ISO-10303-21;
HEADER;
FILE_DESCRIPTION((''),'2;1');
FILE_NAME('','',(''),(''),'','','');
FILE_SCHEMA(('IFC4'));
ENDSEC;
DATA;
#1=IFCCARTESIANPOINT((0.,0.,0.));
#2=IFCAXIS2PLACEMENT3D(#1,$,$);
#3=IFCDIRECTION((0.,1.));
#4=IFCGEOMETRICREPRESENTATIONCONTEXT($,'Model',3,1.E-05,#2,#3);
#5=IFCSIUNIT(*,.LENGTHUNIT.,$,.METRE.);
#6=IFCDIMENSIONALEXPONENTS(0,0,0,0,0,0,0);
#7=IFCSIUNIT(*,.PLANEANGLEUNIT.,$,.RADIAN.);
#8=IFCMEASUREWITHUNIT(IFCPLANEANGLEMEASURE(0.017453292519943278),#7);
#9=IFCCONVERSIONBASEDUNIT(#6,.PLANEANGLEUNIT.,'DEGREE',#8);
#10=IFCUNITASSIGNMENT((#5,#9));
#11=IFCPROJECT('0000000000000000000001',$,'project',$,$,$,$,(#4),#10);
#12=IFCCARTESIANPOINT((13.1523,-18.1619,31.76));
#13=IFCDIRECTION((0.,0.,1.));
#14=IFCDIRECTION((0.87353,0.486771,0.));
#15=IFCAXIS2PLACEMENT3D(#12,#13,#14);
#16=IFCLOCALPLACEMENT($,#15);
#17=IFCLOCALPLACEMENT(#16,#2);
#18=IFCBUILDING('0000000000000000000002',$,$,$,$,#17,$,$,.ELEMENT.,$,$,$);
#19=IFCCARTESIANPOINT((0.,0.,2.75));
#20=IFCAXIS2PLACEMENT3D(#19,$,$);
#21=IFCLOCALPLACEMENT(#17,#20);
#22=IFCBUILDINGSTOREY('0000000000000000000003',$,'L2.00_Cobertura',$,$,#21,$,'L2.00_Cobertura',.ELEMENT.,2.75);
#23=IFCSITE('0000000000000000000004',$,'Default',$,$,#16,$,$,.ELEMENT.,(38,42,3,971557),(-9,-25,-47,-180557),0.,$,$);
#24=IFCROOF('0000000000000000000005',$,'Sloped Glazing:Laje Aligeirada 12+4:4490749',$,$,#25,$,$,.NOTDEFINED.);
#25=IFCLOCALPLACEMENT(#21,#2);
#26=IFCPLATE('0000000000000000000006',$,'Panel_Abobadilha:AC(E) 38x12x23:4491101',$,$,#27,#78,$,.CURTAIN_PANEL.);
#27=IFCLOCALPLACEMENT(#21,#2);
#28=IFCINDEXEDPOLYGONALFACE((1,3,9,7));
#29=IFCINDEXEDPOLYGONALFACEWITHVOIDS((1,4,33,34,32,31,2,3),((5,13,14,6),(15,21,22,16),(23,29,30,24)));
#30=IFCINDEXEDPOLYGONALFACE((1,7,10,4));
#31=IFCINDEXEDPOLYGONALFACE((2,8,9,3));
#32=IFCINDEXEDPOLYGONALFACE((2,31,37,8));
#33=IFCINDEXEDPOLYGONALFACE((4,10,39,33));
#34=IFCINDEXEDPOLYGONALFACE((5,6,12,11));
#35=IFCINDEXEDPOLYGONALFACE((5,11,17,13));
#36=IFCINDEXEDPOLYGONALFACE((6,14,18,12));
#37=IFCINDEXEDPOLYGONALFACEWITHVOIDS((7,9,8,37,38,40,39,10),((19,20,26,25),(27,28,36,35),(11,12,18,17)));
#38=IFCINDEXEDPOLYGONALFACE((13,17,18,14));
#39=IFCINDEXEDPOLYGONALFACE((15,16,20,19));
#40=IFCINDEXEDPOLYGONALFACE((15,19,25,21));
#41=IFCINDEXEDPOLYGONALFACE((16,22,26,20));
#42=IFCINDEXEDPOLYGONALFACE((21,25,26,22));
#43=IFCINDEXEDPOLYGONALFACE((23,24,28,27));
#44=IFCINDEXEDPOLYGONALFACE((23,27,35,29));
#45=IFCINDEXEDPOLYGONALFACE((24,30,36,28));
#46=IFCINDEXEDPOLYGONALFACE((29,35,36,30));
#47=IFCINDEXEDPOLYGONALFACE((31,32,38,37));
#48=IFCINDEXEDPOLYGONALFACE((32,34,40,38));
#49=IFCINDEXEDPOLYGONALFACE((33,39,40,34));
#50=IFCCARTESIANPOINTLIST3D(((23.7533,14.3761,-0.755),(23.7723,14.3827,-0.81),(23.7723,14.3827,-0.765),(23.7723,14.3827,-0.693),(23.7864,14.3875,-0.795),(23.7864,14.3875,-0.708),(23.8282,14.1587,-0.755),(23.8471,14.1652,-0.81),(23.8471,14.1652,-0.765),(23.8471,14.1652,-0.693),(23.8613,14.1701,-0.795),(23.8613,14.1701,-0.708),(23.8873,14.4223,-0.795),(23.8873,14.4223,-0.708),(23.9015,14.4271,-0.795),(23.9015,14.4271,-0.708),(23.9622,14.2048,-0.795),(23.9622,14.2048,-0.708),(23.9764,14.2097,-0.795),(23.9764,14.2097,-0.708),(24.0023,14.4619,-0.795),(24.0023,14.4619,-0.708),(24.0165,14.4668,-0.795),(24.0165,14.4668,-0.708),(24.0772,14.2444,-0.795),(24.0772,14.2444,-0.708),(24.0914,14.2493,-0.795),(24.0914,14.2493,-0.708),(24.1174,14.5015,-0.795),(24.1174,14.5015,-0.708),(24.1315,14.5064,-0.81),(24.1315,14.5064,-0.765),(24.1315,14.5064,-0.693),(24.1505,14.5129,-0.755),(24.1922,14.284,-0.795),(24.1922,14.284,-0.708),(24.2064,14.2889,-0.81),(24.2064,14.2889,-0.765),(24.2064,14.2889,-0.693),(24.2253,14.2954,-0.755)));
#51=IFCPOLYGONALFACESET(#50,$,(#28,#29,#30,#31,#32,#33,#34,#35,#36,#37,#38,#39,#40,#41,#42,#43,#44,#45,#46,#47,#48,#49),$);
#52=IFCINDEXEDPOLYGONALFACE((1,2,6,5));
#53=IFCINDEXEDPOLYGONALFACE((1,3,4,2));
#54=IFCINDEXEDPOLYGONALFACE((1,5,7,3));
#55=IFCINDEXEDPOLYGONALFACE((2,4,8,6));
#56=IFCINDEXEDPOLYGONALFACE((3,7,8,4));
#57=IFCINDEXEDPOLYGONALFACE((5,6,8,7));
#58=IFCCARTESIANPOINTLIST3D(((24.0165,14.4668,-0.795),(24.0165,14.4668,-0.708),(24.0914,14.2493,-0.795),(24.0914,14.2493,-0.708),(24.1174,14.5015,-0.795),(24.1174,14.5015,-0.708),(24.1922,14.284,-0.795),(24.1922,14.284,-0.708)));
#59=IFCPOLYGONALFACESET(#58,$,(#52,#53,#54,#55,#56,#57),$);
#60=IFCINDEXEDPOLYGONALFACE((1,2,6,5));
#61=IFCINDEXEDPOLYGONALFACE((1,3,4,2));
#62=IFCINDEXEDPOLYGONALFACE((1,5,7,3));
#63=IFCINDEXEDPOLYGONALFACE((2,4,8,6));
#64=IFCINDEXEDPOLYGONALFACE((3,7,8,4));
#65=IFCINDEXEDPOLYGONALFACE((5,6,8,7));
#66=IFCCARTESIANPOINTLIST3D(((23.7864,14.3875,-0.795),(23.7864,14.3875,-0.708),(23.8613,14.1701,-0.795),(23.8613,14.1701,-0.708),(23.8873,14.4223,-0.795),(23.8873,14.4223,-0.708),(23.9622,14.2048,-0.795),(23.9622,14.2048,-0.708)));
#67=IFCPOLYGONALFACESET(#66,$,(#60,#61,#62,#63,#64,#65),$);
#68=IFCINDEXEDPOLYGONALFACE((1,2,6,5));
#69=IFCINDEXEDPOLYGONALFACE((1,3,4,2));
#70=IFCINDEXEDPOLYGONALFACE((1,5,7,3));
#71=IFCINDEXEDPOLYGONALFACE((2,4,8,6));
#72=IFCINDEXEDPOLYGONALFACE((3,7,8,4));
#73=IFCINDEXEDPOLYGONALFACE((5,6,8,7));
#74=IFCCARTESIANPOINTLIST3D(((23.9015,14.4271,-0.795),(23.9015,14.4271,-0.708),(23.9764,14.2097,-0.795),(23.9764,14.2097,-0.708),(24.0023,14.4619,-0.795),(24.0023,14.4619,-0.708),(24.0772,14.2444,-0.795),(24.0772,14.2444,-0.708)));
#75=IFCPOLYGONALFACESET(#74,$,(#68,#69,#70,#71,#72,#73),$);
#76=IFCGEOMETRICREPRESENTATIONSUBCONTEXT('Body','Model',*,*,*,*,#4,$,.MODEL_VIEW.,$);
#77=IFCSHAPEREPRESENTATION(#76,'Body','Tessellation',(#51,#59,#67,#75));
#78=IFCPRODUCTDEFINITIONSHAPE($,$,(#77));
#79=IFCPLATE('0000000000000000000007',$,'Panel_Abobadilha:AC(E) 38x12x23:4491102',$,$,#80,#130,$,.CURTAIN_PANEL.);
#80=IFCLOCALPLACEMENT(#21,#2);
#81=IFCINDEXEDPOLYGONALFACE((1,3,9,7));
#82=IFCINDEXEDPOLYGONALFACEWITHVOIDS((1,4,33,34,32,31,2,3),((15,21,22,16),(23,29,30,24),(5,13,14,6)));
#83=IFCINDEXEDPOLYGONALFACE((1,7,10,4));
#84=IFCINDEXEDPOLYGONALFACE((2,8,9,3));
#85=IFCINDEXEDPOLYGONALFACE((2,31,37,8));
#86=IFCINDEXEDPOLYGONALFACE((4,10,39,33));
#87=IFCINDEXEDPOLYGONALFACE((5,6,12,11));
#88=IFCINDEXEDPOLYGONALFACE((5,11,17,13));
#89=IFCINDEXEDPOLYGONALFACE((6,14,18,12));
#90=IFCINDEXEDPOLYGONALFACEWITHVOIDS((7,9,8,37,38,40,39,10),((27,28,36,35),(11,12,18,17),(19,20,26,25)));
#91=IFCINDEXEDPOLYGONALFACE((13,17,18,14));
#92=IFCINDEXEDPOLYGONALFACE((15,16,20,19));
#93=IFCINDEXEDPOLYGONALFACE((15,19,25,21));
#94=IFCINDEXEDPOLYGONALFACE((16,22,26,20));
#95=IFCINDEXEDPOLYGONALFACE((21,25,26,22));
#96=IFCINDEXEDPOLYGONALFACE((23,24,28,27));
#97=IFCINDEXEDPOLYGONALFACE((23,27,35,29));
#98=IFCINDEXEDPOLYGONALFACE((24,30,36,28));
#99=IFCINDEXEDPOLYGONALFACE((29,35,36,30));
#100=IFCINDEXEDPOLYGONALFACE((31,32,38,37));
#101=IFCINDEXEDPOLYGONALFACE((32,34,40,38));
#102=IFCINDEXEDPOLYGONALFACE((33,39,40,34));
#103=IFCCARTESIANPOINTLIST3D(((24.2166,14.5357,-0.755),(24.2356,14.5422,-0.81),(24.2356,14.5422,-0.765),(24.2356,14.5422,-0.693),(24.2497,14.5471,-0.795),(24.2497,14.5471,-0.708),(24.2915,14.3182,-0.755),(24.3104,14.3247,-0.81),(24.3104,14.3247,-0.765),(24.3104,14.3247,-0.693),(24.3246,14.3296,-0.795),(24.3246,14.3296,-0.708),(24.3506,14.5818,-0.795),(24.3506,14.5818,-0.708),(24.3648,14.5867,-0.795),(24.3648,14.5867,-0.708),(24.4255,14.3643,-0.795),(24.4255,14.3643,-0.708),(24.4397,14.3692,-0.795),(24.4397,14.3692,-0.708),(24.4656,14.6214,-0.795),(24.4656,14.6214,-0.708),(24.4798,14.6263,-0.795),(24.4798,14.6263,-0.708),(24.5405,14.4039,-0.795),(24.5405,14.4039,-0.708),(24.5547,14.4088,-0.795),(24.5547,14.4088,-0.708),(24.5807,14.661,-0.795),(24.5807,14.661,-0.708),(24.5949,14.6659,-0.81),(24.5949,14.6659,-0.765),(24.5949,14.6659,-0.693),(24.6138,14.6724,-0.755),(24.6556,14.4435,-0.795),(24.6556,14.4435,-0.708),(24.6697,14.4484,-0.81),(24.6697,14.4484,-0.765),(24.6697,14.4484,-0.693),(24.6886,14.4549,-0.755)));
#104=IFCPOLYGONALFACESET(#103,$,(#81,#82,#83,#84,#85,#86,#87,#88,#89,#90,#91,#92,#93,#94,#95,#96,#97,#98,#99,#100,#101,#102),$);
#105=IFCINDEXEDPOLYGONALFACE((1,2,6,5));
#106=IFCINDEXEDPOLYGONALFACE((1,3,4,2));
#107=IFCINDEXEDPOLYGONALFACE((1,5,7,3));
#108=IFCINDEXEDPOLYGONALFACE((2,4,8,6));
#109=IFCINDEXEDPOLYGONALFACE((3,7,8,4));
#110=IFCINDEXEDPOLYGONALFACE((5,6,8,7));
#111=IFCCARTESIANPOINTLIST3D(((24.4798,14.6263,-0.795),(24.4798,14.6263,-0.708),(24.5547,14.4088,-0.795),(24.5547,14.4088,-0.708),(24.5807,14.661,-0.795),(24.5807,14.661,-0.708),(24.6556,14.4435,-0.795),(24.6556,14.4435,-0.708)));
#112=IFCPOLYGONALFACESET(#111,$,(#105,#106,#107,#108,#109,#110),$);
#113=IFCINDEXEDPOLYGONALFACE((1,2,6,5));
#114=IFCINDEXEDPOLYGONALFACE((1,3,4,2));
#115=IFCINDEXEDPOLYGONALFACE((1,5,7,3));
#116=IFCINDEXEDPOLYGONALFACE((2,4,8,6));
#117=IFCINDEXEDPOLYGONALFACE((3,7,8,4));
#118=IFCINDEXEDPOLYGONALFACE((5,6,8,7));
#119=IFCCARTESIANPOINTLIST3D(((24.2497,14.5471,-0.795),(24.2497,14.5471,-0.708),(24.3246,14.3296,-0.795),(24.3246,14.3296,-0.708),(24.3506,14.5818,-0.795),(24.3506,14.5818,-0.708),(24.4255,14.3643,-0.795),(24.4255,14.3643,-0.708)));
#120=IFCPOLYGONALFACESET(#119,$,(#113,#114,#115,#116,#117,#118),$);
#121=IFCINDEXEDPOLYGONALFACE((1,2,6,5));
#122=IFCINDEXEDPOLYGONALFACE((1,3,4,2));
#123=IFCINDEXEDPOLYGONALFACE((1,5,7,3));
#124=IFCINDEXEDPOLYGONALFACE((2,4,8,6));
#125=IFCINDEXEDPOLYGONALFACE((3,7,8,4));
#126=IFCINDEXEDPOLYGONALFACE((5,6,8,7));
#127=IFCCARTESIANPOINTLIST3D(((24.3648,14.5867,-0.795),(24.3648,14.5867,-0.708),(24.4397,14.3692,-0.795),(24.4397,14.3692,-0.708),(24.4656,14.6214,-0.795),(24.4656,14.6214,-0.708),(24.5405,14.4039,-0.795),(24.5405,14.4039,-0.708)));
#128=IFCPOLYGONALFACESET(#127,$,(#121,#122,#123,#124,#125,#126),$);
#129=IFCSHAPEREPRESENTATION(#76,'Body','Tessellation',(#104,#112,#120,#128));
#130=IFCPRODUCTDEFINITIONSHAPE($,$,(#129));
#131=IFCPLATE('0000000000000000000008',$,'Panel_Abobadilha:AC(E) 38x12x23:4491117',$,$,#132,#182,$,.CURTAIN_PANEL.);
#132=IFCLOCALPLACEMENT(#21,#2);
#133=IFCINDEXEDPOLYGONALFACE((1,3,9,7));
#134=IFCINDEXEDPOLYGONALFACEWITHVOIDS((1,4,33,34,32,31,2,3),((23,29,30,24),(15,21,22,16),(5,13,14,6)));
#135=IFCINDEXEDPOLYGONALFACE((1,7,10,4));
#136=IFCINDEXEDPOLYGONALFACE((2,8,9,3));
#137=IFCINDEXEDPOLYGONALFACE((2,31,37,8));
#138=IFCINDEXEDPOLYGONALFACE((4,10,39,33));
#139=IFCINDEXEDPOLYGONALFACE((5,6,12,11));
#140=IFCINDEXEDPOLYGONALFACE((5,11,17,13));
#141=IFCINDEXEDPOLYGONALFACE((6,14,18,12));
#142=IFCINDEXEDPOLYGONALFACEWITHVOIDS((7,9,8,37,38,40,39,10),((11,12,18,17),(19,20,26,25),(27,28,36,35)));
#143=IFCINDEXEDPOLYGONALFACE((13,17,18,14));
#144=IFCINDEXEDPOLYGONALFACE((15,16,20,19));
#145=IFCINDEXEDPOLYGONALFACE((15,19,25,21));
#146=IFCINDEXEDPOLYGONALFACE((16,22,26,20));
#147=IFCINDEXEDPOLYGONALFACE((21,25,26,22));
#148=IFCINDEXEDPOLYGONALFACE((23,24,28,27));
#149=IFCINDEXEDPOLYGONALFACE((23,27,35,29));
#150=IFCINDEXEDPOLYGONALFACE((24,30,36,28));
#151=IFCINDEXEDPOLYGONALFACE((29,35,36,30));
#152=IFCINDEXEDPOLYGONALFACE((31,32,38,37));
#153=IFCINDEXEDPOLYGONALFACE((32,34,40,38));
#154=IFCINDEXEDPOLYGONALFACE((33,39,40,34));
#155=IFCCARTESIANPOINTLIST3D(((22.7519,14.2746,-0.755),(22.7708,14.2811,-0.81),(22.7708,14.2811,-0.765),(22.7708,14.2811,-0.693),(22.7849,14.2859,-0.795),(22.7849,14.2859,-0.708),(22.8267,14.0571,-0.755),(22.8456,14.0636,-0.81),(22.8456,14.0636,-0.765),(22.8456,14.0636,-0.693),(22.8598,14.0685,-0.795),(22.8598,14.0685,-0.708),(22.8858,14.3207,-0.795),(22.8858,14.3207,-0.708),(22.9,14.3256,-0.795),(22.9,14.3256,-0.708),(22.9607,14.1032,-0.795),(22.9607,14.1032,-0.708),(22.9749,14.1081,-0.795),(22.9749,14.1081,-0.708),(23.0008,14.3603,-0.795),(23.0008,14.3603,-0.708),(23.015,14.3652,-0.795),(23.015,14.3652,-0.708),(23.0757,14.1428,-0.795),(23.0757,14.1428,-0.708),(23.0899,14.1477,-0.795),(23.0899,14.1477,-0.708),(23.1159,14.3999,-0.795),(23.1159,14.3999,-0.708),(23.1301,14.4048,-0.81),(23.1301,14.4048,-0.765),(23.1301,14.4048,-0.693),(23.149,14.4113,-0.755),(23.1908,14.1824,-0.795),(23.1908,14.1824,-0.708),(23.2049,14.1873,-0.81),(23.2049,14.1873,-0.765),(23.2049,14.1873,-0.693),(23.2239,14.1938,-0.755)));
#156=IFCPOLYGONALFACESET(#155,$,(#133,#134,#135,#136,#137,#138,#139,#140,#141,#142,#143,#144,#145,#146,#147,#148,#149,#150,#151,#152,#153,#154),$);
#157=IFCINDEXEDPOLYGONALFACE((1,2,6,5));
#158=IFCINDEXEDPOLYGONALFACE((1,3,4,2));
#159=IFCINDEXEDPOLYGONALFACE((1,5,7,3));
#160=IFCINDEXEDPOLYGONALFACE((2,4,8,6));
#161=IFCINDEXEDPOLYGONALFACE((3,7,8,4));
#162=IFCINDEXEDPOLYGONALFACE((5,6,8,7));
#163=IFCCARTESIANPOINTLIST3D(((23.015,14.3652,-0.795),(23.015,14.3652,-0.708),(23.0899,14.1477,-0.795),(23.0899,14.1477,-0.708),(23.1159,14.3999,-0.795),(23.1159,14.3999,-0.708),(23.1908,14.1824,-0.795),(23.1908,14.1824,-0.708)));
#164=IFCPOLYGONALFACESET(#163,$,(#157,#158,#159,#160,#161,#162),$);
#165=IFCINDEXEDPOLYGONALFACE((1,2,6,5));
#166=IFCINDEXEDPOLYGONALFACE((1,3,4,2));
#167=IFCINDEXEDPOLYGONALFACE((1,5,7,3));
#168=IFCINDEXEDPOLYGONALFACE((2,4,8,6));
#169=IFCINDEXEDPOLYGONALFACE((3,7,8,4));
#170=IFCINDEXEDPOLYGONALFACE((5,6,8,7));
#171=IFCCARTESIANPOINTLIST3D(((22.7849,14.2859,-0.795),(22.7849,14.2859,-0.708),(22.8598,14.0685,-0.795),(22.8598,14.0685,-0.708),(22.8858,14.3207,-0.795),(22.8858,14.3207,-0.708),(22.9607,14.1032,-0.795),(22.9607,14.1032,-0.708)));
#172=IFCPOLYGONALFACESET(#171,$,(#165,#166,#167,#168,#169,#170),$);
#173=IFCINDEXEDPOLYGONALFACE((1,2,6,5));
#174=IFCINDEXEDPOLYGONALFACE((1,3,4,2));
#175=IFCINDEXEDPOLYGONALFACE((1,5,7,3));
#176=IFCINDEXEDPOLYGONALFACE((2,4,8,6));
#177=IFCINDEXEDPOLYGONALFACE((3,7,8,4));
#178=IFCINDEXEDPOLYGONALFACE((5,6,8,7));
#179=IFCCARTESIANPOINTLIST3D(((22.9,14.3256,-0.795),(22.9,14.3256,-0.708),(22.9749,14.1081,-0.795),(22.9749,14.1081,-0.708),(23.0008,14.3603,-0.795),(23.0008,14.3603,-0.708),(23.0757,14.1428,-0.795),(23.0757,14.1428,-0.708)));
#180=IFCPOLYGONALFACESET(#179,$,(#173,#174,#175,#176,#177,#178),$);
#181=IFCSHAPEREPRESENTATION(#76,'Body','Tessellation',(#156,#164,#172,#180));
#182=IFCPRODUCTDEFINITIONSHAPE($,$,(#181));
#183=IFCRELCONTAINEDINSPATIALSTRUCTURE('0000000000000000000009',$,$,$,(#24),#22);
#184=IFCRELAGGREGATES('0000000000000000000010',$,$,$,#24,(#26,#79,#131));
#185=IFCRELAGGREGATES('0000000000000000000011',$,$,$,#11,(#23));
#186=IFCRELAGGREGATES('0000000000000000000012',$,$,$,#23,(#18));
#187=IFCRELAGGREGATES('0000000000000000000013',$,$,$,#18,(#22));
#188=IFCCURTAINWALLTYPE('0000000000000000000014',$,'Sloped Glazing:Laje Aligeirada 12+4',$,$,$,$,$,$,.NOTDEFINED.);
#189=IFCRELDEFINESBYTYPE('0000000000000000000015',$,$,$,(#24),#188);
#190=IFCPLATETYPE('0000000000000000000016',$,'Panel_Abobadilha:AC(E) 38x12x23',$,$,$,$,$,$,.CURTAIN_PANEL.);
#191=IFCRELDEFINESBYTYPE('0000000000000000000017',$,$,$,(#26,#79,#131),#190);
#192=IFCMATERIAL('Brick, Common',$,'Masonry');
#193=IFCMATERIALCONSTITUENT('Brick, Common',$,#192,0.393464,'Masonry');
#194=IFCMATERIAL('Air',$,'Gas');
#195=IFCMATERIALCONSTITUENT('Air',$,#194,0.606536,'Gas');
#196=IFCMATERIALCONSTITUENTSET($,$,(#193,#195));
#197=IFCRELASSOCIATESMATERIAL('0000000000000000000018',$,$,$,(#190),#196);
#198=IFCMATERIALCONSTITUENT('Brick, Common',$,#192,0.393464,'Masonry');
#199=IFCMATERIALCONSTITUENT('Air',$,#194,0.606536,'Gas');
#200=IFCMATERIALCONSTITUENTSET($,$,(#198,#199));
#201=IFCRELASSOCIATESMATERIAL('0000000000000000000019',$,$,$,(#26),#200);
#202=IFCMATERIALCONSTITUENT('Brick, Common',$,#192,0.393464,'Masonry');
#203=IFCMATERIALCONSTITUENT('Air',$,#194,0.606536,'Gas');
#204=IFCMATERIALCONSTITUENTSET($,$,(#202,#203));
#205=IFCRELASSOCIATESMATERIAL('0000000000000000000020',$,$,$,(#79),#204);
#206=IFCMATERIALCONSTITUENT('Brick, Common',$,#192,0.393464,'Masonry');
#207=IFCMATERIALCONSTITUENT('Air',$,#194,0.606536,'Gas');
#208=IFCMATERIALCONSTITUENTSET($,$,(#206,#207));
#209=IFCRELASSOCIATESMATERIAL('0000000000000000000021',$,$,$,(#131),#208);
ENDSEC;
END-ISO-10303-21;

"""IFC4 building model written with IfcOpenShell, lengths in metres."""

from ifc_helpers import new_model, entity, si_unit, converted_unit, direction, frame, origin, place, context, subcontext, project, spatial, indexed_curve, outline, extrude, source, transform, mapped, material, constituent, constituent_set, type_object, type_shapes, element, aggregate, save


model = new_model("IFC4")

# Units and contexts
model_context = context("Model", 3, precision=1e-05, world=origin(), true_north=direction((0.0, 1.0)))
body_context = subcontext(model_context, "Body", "Model", "MODEL_VIEW")
ifc_project = project(units=[si_unit("LENGTHUNIT", "METRE"), converted_unit("PLANEANGLEUNIT", "DEGREE", entity("IfcPlaneAngleMeasure", 0.017453292519943278), si_unit("PLANEANGLEUNIT", "RADIAN"), dimensions=[0, 0, 0, 0, 0, 0, 0])], contexts=[model_context])

# Site, building, storey
site_placement = place(None, frame((13.1523, -18.1619, 31.76), z_axis=(0.0, 0.0, 1.0), x_axis=(0.87353, 0.486771, 0.0)))
site = spatial("IfcSite", under=ifc_project, at=site_placement, Name="Default", CompositionType="ELEMENT", RefLatitude=(38, 42, 3, 971557), RefLongitude=(-9, -25, -47, -180557), RefElevation=0.0)
building_placement = place(site_placement, origin())
building = spatial("IfcBuilding", under=site, at=building_placement, CompositionType="ELEMENT")
storey_placement = place(building_placement, frame((0.0, 0.0, 2.75)))
storey = spatial("IfcBuildingStorey", under=building, at=storey_placement, Name="L2.00_Cobertura", LongName="L2.00_Cobertura", CompositionType="ELEMENT", Elevation=2.75)

# Roof, plates
curtain_wall_type = type_object("IfcCurtainWallType", Name="Sloped Glazing:Laje Aligeirada 12+4", PredefinedType="NOTDEFINED")
roof_placement = place(storey_placement, frame((0.0, 0.0, -2.75)))
roof = element("IfcRoof", 1, at=roof_placement, inside=storey, type_object=curtain_wall_type, Name="Sloped Glazing:Laje Aligeirada 12+4:4490749", PredefinedType="NOTDEFINED")
ifc_material_1 = material(Name="Brick, Common", Category="Masonry")
ifc_material_2 = material(Name="Air", Category="Gas")
ifc_constituent_1 = constituent(ifc_material_1, Name="Brick, Common", Category="Masonry", fraction=0.393464)
ifc_constituent_2 = constituent(ifc_material_2, Name="Air", Category="Gas", fraction=0.606536)
ifc_constituent_set_1 = constituent_set(constituents=[ifc_constituent_1, ifc_constituent_2])
plate_type = type_object("IfcPlateType", Name="Panel_Abobadilha:AC(E) 38x12x23", PredefinedType="CURTAIN_PANEL", material=ifc_constituent_set_1)
shared_shape_1 = source(origin(), body_context, "Body", "SweptSolid", [
    extrude(outline(indexed_curve([(-0.19, -0.0543), (0.19, -0.0543), (0.19, -0.0093), (0.21, 0.0007), (0.19, 0.0628), (-0.19, 0.0628), (-0.21, 0.0007), (-0.19, -0.0093), (-0.19, -0.0543)], self_intersect=False), holes=[indexed_curve([(-0.0683, 0.0477), (-0.0683, -0.0393), (-0.175, -0.0393), (-0.175, 0.0477), (-0.0683, 0.0477)], self_intersect=False), indexed_curve([(0.0533, 0.0477), (0.0533, -0.0393), (-0.0533, -0.0393), (-0.0533, 0.0477), (0.0533, 0.0477)], self_intersect=False), indexed_curve([(0.175, 0.0477), (0.175, -0.0393), (0.0683, -0.0393), (0.0683, 0.0477), (0.175, 0.0477)], self_intersect=False)]), frame((0.0, 0.0543, 0.0)), (0.0, 0.0, 1.0), 0.23),
    extrude(outline(indexed_curve([(-0.0533, -0.0435), (0.0533, -0.0435), (0.0533, 0.0435), (-0.0533, 0.0435), (-0.0533, -0.0435)], self_intersect=False)), frame((0.1217, 0.0585, 0.0), z_axis=(0.0, 0.0, 1.0), x_axis=(-1.0, 0.0, 0.0)), (0.0, 0.0, 1.0), 0.23),
    extrude(outline(indexed_curve([(-0.0533, -0.0435), (0.0533, -0.0435), (0.0533, 0.0435), (-0.0533, 0.0435), (-0.0533, -0.0435)], self_intersect=False)), frame((-0.1217, 0.0585, 0.0), z_axis=(0.0, 0.0, 1.0), x_axis=(-1.0, 0.0, 0.0)), (0.0, 0.0, 1.0), 0.23),
    extrude(outline(indexed_curve([(-0.0533, -0.0435), (0.0533, -0.0435), (0.0533, 0.0435), (-0.0533, 0.0435), (-0.0533, -0.0435)], self_intersect=False)), frame((0.0, 0.0585, 0.0), z_axis=(0.0, 0.0, 1.0), x_axis=(-1.0, 0.0, 0.0)), (0.0, 0.0, 1.0), 0.23),
])
type_shapes(plate_type, [shared_shape_1])
ifc_constituent_3 = constituent(ifc_material_1, Name="Brick, Common", Category="Masonry", fraction=0.393464)
ifc_constituent_4 = constituent(ifc_material_2, Name="Air", Category="Gas", fraction=0.606536)
ifc_constituent_set_2 = constituent_set(constituents=[ifc_constituent_3, ifc_constituent_4])
plate_1_placement = place(roof_placement, frame((23.9519, 14.4445, 1.94), z_axis=(0.325568, -0.945519, 0.0), x_axis=(0.945519, 0.325568, 0.0)))
plate_1 = element("IfcPlate", 2, at=plate_1_placement, type_object=plate_type, material=ifc_constituent_set_2, Name="Panel_Abobadilha:AC(E) 38x12x23:4491101", PredefinedType="CURTAIN_PANEL", context=body_context, shape_type="MappedRepresentation", body=[
    mapped(shared_shape_1, transform((0.0, 0.0, 0.0), scale=1.0)),
])
ifc_constituent_5 = constituent(ifc_material_1, Name="Brick, Common", Category="Masonry", fraction=0.393464)
ifc_constituent_6 = constituent(ifc_material_2, Name="Air", Category="Gas", fraction=0.606536)
ifc_constituent_set_3 = constituent_set(constituents=[ifc_constituent_5, ifc_constituent_6])
plate_2_placement = place(roof_placement, frame((24.4152, 14.604, 1.94), z_axis=(0.325568, -0.945519, 0.0), x_axis=(0.945519, 0.325568, 0.0)))
plate_2 = element("IfcPlate", 3, at=plate_2_placement, type_object=plate_type, material=ifc_constituent_set_3, Name="Panel_Abobadilha:AC(E) 38x12x23:4491102", PredefinedType="CURTAIN_PANEL", context=body_context, shape_type="MappedRepresentation", body=[
    mapped(shared_shape_1, transform((0.0, 0.0, 0.0), scale=1.0)),
])
ifc_constituent_7 = constituent(ifc_material_1, Name="Brick, Common", Category="Masonry", fraction=0.393464)
ifc_constituent_8 = constituent(ifc_material_2, Name="Air", Category="Gas", fraction=0.606536)
ifc_constituent_set_4 = constituent_set(constituents=[ifc_constituent_7, ifc_constituent_8])
plate_3_placement = place(roof_placement, frame((22.9504, 14.3429, 1.94), z_axis=(0.325568, -0.945519, 0.0), x_axis=(0.945519, 0.325568, 0.0)))
plate_3 = element("IfcPlate", 4, at=plate_3_placement, type_object=plate_type, material=ifc_constituent_set_4, Name="Panel_Abobadilha:AC(E) 38x12x23:4491117", PredefinedType="CURTAIN_PANEL", context=body_context, shape_type="MappedRepresentation", body=[
    mapped(shared_shape_1, transform((0.0, 0.0, 0.0), scale=1.0)),
])
aggregate(roof, [plate_1, plate_2, plate_3])

save(model, "model.ifc")
